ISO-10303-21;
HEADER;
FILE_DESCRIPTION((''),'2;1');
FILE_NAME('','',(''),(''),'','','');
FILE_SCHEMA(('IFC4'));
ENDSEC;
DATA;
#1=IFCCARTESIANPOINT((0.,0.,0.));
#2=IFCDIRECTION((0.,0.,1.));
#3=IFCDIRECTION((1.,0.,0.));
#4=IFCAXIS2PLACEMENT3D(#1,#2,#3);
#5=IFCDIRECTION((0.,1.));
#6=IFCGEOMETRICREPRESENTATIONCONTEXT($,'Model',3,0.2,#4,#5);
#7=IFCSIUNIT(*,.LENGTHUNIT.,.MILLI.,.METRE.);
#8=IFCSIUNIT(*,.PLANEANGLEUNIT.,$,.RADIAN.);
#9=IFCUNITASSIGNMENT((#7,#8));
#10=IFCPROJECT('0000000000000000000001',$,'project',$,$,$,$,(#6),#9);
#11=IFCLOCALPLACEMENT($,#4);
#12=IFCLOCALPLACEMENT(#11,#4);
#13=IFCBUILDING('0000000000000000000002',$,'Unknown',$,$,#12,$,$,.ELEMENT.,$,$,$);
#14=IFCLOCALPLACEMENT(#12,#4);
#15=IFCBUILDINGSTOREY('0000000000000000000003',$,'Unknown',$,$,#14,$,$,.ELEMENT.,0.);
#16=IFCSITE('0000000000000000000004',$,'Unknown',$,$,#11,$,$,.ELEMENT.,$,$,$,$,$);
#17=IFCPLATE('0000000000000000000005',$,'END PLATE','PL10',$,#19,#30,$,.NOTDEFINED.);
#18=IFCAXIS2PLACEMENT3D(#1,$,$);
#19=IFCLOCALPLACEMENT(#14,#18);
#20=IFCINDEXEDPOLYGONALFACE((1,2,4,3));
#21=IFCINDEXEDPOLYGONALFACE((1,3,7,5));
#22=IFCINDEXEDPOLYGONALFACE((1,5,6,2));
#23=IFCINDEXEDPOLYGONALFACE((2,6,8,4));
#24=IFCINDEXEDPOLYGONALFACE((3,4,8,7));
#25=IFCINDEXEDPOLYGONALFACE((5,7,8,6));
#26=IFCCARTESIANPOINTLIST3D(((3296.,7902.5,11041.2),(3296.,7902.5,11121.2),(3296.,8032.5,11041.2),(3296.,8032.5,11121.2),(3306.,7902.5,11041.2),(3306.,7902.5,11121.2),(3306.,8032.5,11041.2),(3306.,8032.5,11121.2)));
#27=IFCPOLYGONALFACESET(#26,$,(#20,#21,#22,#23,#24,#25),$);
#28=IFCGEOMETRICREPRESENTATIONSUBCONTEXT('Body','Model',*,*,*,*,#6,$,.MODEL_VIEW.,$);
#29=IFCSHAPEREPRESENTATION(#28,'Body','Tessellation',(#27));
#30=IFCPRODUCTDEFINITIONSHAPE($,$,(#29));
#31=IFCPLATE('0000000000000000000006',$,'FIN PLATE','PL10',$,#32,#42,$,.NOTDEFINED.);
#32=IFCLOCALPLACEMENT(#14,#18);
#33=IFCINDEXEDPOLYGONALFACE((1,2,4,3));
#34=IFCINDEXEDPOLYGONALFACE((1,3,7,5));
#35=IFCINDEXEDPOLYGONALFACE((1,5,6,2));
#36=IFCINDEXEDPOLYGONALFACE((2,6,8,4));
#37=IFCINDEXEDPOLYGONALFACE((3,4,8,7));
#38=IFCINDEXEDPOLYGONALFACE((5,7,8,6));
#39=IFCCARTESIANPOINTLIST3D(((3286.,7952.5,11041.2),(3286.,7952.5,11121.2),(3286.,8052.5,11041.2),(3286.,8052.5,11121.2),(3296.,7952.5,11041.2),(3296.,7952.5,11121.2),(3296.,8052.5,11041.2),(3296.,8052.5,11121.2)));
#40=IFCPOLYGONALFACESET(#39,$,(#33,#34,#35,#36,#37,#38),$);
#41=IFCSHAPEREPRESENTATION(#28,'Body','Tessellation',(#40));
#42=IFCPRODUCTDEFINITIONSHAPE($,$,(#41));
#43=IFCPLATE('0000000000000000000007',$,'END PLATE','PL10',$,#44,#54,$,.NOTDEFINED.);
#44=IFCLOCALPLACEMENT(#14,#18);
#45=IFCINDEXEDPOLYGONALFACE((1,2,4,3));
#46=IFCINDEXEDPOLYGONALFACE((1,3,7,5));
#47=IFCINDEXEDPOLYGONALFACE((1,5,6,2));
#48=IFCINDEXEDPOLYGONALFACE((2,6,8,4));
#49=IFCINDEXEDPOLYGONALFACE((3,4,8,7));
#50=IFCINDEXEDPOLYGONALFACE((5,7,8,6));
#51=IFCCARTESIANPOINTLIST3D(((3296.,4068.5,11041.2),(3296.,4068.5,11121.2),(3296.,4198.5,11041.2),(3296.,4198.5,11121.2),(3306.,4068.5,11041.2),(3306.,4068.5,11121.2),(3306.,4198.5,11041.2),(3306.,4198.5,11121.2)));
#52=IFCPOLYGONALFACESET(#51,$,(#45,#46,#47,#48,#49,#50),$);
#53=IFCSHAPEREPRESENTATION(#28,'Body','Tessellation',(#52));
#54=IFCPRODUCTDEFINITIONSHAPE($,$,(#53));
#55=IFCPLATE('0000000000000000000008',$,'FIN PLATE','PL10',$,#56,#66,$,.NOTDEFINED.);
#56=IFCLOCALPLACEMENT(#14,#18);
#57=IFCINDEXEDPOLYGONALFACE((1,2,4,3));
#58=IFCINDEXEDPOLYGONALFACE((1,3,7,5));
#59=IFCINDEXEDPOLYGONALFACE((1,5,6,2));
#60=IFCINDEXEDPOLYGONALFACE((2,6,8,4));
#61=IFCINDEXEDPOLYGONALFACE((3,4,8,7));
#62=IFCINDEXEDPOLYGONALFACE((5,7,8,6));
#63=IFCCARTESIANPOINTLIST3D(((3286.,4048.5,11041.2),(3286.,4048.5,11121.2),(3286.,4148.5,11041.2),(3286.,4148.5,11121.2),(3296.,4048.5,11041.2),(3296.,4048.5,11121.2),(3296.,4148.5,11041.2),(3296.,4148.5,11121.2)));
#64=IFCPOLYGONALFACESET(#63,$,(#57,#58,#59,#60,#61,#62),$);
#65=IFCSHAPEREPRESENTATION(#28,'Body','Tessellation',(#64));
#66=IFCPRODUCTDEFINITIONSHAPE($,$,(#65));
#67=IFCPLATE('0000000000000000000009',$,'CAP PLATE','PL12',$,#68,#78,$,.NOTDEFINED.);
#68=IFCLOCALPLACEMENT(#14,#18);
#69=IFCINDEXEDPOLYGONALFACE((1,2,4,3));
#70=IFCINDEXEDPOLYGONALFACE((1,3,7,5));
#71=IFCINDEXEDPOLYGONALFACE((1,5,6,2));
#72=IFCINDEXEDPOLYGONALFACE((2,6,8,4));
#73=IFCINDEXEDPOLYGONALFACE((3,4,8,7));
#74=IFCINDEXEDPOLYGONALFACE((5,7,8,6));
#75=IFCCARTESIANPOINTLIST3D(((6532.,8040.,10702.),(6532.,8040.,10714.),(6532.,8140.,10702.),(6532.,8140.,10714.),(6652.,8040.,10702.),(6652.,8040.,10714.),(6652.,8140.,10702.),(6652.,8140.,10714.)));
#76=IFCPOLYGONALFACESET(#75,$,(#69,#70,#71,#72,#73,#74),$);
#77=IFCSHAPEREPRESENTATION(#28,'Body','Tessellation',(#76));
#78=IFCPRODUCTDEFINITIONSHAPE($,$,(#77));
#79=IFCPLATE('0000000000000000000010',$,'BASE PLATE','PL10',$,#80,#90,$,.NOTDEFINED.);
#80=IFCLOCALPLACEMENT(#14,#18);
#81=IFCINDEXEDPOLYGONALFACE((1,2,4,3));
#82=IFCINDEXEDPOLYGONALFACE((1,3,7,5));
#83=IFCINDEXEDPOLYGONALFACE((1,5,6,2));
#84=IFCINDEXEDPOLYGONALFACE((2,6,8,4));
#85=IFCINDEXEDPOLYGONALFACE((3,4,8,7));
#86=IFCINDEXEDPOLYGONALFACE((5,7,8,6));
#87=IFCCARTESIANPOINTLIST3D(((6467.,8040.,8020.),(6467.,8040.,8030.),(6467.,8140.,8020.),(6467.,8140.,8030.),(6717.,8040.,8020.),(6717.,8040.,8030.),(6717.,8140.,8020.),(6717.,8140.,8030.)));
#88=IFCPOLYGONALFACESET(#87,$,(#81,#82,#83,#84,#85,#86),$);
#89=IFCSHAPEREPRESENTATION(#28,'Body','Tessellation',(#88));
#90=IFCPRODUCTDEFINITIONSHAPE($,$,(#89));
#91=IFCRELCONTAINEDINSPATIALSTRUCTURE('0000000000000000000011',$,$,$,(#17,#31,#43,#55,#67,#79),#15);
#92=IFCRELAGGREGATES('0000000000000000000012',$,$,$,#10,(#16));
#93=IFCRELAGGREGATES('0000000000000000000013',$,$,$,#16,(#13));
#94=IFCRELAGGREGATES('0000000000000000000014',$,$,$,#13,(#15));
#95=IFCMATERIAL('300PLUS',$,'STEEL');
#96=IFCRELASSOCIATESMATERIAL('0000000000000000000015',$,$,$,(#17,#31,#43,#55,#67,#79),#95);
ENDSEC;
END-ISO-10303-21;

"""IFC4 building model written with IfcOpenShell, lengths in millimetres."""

from ifc_helpers import new_model, si_unit, direction, frame, origin_with_axes, place, context, subcontext, project, spatial, line, indexed_curve, outline, extrude, material, element, save


model = new_model("IFC4")

# Units and contexts
model_context = context("Model", 3, precision=0.2, world=origin_with_axes(), true_north=direction((0.0, 1.0)))
body_context = subcontext(model_context, "Body", "Model", "MODEL_VIEW")
ifc_project = project(units=[si_unit("LENGTHUNIT", "METRE", prefix="MILLI"), si_unit("PLANEANGLEUNIT", "RADIAN")], contexts=[model_context])

# Site, building, storey
site_placement = place(None, origin_with_axes())
site = spatial("IfcSite", under=ifc_project, at=site_placement, Name="Unknown", CompositionType="ELEMENT")
building_placement = place(site_placement, origin_with_axes())
building = spatial("IfcBuilding", under=site, at=building_placement, Name="Unknown", CompositionType="ELEMENT")
storey_placement = place(building_placement, origin_with_axes())
storey = spatial("IfcBuildingStorey", under=building, at=storey_placement, Name="Unknown", CompositionType="ELEMENT", Elevation=0.0)

# Plates
ifc_material_1 = material(Name="300PLUS", Category="STEEL")
plate_1_placement = place(storey_placement, frame((3301.0, 7902.5, 11041.2), z_axis=(1.0, 0.0, 0.0), x_axis=(0.0, 1.0, 0.0)))
element("IfcPlate", 1, at=plate_1_placement, inside=storey, material=ifc_material_1, Name="END PLATE", Description="PL10", PredefinedType="NOTDEFINED", context=body_context, shape_type="SolidModel", body=[
    extrude(outline(indexed_curve([(0.0, 0.0), (130.0, 0.0), (130.0, 80.0), (0.0, 80.0)], segments=[line(1, 2, 3, 4, 1)])), frame((0.0, 0.0, 5.0), z_axis=(0.0, 0.0, 1.0), x_axis=(1.0, 0.0, 0.0)), (0.0, 0.0, -1.0), 10.0),
])
plate_2_placement = place(storey_placement, frame((3291.0, 8052.5, 11041.2), z_axis=(-1.0, 0.0, 0.0), x_axis=(0.0, -1.0, 0.0)))
element("IfcPlate", 2, at=plate_2_placement, inside=storey, material=ifc_material_1, Name="FIN PLATE", Description="PL10", PredefinedType="NOTDEFINED", context=body_context, shape_type="SolidModel", body=[
    extrude(outline(indexed_curve([(0.0, 0.0), (100.0, 0.0), (100.0, 80.0), (0.0, 80.0)], segments=[line(1, 2, 3, 4, 1)])), frame((0.0, 0.0, 5.0), z_axis=(0.0, 0.0, 1.0), x_axis=(1.0, 0.0, 0.0)), (0.0, 0.0, -1.0), 10.0),
])
plate_3_placement = place(storey_placement, frame((3301.0, 4198.5, 11121.2), z_axis=(1.0, 0.0, 0.0), x_axis=(0.0, -1.0, 0.0)))
element("IfcPlate", 3, at=plate_3_placement, inside=storey, material=ifc_material_1, Name="END PLATE", Description="PL10", PredefinedType="NOTDEFINED", context=body_context, shape_type="SolidModel", body=[
    extrude(outline(indexed_curve([(0.0, 0.0), (130.0, 0.0), (130.0, 80.0), (0.0, 80.0)], segments=[line(1, 2, 3, 4, 1)])), frame((0.0, 0.0, 5.0), z_axis=(0.0, 0.0, 1.0), x_axis=(1.0, 0.0, 0.0)), (0.0, 0.0, -1.0), 10.0),
])
plate_4_placement = place(storey_placement, frame((3291.0, 4048.5, 11121.2), z_axis=(-1.0, 0.0, 0.0), x_axis=(0.0, 1.0, 0.0)))
element("IfcPlate", 4, at=plate_4_placement, inside=storey, material=ifc_material_1, Name="FIN PLATE", Description="PL10", PredefinedType="NOTDEFINED", context=body_context, shape_type="SolidModel", body=[
    extrude(outline(indexed_curve([(0.0, 0.0), (100.0, 0.0), (100.0, 80.0), (0.0, 80.0)], segments=[line(1, 2, 3, 4, 1)])), frame((0.0, 0.0, 5.0), z_axis=(0.0, 0.0, 1.0), x_axis=(1.0, 0.0, 0.0)), (0.0, 0.0, -1.0), 10.0),
])
plate_5_placement = place(storey_placement, frame((6532.0, 8040.0, 10708.0), z_axis=(0.0, 0.0, 1.0), x_axis=(1.0, 0.0, 0.0)))
element("IfcPlate", 5, at=plate_5_placement, inside=storey, material=ifc_material_1, Name="CAP PLATE", Description="PL12", PredefinedType="NOTDEFINED", context=body_context, shape_type="SolidModel", body=[
    extrude(outline(indexed_curve([(0.0, 0.0), (120.0, 0.0), (120.0, 100.0), (0.0, 100.0)], segments=[line(1, 2, 3, 4, 1)])), frame((0.0, 0.0, 6.0), z_axis=(0.0, 0.0, 1.0), x_axis=(1.0, 0.0, 0.0)), (0.0, 0.0, -1.0), 12.0),
])
plate_6_placement = place(storey_placement, frame((6467.0, 8040.0, 8025.0), z_axis=(0.0, 0.0, 1.0), x_axis=(1.0, 0.0, 0.0)))
element("IfcPlate", 6, at=plate_6_placement, inside=storey, material=ifc_material_1, Name="BASE PLATE", Description="PL10", PredefinedType="NOTDEFINED", context=body_context, shape_type="SolidModel", body=[
    extrude(outline(indexed_curve([(0.0, 0.0), (250.0, 0.0), (250.0, 100.0), (0.0, 100.0)], segments=[line(1, 2, 3, 4, 1)])), frame((0.0, 0.0, 5.0), z_axis=(0.0, 0.0, 1.0), x_axis=(1.0, 0.0, 0.0)), (0.0, 0.0, -1.0), 10.0),
])

save(model, "model.ifc")
